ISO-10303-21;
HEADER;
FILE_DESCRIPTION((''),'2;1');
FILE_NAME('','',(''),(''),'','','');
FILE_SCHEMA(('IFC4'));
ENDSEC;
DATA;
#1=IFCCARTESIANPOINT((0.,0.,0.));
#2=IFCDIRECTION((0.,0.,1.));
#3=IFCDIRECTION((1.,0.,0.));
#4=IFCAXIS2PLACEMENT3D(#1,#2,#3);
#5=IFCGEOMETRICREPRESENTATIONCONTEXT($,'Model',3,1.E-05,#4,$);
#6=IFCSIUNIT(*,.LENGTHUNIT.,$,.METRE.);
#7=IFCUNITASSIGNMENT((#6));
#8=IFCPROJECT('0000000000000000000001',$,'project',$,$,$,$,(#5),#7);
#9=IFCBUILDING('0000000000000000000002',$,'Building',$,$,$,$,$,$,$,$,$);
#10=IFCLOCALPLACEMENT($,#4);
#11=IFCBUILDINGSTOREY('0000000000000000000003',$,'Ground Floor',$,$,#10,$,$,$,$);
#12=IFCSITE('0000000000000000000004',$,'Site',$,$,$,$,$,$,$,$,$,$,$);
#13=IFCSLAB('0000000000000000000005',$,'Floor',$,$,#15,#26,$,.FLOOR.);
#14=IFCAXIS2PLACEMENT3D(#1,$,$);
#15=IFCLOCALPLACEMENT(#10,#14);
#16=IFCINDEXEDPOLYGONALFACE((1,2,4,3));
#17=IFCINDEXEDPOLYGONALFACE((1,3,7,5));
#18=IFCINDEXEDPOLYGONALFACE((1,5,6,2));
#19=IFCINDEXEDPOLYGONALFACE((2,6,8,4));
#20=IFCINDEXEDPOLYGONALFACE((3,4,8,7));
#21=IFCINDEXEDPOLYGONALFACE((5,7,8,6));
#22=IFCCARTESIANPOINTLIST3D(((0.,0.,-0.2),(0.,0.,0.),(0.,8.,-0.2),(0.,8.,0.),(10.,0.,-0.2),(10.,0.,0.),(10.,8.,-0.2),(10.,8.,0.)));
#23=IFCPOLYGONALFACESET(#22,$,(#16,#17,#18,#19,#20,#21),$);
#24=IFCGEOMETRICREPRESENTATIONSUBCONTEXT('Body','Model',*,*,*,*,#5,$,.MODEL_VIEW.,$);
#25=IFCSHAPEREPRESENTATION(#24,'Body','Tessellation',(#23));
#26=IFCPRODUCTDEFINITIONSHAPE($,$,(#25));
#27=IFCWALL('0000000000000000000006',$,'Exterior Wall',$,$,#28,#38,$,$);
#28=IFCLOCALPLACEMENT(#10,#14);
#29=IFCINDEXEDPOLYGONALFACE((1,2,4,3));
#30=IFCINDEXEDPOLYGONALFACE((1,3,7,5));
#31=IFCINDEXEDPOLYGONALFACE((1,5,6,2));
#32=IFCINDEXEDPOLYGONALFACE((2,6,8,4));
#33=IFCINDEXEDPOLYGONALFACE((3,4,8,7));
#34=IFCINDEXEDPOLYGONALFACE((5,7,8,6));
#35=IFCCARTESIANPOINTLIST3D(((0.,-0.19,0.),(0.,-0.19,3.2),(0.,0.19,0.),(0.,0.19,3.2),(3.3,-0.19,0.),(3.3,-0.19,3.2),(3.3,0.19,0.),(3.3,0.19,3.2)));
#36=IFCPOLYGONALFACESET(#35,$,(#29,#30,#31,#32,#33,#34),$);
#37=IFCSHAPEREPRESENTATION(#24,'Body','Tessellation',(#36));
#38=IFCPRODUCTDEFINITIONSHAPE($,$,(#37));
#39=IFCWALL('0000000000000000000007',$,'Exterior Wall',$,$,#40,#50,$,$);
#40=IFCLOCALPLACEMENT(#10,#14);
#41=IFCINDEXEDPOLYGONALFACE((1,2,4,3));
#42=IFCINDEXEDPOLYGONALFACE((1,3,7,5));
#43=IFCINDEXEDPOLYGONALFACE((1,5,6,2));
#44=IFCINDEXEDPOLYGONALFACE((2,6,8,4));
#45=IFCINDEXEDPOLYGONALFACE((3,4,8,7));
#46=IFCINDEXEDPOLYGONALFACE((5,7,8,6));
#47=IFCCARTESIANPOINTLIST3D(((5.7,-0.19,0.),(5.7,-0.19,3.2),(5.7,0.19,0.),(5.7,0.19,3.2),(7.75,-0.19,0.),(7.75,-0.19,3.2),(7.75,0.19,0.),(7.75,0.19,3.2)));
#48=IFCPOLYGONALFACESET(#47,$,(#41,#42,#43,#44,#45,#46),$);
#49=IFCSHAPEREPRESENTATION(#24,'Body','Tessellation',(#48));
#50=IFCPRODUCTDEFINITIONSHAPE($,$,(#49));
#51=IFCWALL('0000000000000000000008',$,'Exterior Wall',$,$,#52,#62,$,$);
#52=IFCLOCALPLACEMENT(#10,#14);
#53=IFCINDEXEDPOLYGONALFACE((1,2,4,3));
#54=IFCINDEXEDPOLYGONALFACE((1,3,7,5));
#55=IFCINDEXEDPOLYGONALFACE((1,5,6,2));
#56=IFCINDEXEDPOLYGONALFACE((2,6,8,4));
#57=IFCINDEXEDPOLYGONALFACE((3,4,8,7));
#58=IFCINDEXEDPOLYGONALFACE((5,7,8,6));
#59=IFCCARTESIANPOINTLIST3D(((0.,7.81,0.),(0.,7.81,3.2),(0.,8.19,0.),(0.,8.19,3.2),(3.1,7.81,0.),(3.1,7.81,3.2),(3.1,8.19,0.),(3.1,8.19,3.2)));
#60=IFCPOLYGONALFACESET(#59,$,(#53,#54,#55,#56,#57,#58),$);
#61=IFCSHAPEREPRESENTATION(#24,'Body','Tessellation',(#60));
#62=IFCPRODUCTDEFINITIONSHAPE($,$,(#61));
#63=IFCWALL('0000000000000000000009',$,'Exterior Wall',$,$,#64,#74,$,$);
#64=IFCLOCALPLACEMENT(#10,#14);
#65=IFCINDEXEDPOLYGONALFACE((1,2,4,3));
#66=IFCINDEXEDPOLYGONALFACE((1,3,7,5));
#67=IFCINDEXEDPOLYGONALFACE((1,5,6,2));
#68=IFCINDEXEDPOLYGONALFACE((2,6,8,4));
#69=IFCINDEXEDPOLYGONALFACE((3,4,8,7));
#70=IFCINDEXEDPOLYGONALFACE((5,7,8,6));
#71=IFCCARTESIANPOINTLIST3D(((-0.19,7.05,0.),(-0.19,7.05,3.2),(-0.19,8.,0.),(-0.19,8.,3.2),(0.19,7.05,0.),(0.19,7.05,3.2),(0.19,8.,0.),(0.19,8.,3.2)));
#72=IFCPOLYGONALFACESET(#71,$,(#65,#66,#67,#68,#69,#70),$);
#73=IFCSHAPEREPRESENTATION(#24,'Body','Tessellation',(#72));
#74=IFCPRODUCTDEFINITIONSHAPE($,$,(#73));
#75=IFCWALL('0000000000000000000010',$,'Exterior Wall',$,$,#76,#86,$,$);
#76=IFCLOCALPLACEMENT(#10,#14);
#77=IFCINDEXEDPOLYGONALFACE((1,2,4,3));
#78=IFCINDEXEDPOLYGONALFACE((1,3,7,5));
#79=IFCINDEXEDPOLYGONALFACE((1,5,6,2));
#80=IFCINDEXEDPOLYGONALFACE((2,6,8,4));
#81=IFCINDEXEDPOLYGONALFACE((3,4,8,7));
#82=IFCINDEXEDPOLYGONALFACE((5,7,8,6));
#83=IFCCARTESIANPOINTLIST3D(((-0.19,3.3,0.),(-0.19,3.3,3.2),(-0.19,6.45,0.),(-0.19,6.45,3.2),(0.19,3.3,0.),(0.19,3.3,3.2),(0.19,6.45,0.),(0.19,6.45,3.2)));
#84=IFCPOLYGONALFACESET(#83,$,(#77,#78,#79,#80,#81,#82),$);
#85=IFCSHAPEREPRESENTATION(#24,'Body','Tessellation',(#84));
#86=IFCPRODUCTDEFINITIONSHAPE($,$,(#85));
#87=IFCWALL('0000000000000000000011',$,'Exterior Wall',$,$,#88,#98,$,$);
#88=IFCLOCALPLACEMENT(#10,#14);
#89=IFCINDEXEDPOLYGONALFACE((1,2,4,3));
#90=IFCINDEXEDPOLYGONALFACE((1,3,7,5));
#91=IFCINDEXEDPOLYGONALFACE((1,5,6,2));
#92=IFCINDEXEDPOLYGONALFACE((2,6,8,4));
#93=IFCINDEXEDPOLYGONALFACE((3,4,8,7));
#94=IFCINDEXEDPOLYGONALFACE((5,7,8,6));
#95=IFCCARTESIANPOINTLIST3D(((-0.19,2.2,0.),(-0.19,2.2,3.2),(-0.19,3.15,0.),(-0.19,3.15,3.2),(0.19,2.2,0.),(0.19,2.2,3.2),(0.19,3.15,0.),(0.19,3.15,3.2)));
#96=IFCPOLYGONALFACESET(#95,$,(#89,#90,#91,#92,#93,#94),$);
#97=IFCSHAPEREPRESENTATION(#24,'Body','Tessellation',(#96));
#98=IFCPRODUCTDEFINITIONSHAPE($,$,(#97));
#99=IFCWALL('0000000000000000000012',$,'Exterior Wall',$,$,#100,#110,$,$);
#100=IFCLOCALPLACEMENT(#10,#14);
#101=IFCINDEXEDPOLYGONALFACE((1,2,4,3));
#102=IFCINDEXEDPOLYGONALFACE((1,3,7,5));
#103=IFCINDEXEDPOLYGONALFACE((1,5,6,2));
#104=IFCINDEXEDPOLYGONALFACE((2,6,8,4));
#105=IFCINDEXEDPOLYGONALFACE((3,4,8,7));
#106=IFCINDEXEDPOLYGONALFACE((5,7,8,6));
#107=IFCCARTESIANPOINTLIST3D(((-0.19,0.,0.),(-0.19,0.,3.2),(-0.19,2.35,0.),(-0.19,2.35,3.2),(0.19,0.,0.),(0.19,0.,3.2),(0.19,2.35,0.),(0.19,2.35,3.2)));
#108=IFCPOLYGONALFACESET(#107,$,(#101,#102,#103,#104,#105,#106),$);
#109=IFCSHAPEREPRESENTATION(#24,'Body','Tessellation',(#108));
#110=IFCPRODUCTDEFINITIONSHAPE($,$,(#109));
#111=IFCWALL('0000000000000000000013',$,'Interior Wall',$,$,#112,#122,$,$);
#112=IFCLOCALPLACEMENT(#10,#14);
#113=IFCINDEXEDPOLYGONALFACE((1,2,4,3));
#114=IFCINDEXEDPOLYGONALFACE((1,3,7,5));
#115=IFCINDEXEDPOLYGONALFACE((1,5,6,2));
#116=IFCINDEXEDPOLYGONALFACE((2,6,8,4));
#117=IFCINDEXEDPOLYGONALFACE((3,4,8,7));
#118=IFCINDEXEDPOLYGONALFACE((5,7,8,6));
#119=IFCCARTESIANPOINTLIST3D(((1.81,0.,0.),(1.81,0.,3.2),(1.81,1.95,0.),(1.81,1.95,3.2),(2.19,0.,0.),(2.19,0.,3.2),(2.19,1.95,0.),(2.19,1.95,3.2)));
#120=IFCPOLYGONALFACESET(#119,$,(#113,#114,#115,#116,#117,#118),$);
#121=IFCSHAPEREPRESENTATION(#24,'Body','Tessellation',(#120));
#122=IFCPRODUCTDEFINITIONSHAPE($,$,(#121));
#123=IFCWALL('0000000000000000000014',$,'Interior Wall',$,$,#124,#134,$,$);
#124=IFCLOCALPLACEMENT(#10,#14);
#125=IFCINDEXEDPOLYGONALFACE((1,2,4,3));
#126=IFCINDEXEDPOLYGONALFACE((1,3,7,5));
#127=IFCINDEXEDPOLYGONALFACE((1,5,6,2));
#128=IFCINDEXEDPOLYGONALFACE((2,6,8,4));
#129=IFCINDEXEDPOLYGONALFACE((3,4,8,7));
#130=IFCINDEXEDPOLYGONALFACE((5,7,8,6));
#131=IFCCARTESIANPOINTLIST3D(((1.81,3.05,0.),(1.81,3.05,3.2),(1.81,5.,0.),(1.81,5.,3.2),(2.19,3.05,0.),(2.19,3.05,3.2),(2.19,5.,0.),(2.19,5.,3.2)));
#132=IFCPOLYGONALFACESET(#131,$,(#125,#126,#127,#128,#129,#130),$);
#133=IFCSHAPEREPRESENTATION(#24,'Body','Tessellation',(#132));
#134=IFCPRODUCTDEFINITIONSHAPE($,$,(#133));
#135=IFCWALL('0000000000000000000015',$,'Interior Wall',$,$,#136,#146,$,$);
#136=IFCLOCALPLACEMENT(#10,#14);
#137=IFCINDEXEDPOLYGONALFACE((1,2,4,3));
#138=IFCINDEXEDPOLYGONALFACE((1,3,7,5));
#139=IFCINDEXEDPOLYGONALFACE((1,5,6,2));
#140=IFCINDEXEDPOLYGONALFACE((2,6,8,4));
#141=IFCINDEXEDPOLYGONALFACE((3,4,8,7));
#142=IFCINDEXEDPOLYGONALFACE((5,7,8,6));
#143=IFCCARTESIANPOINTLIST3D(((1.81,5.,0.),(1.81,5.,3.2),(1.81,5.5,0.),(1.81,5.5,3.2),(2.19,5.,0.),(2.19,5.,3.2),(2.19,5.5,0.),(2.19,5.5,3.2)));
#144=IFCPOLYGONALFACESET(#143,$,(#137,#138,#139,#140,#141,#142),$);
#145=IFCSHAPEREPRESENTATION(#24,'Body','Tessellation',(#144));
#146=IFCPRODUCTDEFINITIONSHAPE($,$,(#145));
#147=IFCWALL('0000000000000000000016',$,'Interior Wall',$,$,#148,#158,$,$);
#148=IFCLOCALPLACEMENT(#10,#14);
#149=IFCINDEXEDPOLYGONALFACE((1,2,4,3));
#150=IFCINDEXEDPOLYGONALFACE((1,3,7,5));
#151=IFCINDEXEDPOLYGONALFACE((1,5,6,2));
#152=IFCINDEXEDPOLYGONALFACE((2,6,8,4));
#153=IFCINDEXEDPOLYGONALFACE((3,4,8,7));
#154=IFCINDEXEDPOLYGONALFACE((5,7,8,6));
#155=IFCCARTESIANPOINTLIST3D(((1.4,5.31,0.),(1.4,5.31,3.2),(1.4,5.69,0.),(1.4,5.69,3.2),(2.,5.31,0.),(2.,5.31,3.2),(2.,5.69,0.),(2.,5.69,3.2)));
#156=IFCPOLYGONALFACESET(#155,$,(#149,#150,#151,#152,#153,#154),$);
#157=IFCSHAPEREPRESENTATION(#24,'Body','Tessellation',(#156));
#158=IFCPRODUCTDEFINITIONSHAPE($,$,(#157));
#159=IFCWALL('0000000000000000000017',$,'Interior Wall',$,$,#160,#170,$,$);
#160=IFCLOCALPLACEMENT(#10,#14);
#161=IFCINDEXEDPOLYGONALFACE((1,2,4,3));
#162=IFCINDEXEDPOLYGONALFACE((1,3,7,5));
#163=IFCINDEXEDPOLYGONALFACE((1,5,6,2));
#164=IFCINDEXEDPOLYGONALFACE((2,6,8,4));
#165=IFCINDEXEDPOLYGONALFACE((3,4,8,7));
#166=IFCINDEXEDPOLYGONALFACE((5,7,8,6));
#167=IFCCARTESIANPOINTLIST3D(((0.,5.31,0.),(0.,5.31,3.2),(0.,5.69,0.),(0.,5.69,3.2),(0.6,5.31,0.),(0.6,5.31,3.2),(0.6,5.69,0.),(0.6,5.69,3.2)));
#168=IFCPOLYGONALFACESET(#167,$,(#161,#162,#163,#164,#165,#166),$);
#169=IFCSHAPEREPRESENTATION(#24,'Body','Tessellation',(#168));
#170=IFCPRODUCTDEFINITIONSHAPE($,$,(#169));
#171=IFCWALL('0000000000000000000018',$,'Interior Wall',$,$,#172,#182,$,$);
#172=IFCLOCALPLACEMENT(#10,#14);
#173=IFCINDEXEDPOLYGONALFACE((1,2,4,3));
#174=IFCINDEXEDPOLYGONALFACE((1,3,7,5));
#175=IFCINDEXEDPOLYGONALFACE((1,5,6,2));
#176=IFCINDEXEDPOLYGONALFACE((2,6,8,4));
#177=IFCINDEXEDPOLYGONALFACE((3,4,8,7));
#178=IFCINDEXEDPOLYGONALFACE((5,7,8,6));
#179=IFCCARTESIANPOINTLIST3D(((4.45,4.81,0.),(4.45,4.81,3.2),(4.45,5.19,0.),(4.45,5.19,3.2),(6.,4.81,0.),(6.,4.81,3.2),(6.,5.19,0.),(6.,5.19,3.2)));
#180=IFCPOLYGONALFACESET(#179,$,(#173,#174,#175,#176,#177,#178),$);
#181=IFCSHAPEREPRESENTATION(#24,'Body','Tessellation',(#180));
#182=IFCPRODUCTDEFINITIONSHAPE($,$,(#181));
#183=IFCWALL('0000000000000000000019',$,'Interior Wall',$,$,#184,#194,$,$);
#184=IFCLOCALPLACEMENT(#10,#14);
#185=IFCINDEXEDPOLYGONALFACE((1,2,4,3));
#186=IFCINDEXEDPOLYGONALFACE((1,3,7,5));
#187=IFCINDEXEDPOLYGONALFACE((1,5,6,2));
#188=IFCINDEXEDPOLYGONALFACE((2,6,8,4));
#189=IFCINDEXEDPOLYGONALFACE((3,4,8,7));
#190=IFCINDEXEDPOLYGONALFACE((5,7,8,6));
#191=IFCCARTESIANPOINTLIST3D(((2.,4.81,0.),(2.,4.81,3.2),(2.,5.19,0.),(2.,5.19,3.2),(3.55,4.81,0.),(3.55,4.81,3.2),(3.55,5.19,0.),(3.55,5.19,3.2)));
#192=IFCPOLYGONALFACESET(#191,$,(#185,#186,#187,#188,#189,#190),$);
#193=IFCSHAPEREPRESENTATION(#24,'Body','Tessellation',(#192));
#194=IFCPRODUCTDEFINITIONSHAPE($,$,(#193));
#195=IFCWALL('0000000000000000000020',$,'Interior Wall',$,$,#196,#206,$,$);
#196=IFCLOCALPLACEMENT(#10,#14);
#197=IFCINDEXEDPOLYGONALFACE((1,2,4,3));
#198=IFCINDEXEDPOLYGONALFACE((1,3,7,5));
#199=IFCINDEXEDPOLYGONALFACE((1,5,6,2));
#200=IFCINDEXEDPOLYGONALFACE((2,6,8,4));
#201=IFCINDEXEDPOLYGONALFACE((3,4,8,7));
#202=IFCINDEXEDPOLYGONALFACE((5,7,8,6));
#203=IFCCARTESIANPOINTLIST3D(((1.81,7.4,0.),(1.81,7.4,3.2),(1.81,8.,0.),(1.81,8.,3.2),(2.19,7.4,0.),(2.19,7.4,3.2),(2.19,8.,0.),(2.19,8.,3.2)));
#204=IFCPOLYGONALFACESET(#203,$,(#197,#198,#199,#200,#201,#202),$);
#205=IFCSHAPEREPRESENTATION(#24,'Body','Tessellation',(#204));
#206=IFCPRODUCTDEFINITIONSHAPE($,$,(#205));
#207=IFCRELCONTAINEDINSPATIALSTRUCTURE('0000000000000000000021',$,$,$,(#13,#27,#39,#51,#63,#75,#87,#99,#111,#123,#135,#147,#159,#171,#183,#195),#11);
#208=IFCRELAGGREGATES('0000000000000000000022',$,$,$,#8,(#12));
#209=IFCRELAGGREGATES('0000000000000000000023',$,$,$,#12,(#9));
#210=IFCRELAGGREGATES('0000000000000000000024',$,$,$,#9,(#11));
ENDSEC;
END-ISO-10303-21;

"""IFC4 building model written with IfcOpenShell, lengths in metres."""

from ifc_helpers import new_model, si_unit, frame, origin_with_axes, place, context, subcontext, project, spatial, indexed_curve, outline, extrude, element, save


model = new_model("IFC4")

# Units and contexts
model_context = context("Model", 3, precision=1e-05, world=origin_with_axes())
body_context = subcontext(model_context, "Body", "Model", "MODEL_VIEW")
ifc_project = project(units=[si_unit("LENGTHUNIT", "METRE")], contexts=[model_context])

# Site, building, storey
site = spatial("IfcSite", under=ifc_project, Name="Site")
building = spatial("IfcBuilding", under=site, Name="Building")
storey_placement = place(None, origin_with_axes())
storey = spatial("IfcBuildingStorey", under=building, at=storey_placement, Name="Ground Floor")

# Slab
slab_placement = place(storey_placement, frame((0.0, 0.0, -0.2), z_axis=(0.0, 0.0, 1.0), x_axis=(1.0, 0.0, 0.0)))
element("IfcSlab", 1, at=slab_placement, inside=storey, Name="Floor", PredefinedType="FLOOR", context=body_context, shape_type="SweptSolid", body=[
    extrude(outline(indexed_curve([(0.0, 0.0), (10.0, 0.0), (10.0, 8.0), (0.0, 8.0)])), None, (0.0, 0.0, 1.0), 0.2),
])

# Walls
wall_1_placement = place(storey_placement, origin_with_axes())
element("IfcWall", 2, at=wall_1_placement, inside=storey, Name="Exterior Wall", context=body_context, shape_type="SweptSolid", body=[
    extrude(outline(indexed_curve([(0.0, 0.0), (0.0, 0.38), (3.3, 0.38), (3.3, 0.0), (0.0, 0.0)], self_intersect=False)), frame((0.0, -0.19, 0.0), z_axis=(0.0, 0.0, 1.0), x_axis=(1.0, 0.0, 0.0)), (0.0, 0.0, 1.0), 3.2),
])
wall_2_placement = place(storey_placement, frame((5.7, 0.0, 0.0), z_axis=(0.0, 0.0, 1.0), x_axis=(1.0, 0.0, 0.0)))
element("IfcWall", 3, at=wall_2_placement, inside=storey, Name="Exterior Wall", context=body_context, shape_type="SweptSolid", body=[
    extrude(outline(indexed_curve([(0.0, 0.0), (0.0, 0.38), (2.05, 0.38), (2.05, 0.0), (0.0, 0.0)], self_intersect=False)), frame((0.0, -0.19, 0.0), z_axis=(0.0, 0.0, 1.0), x_axis=(1.0, 0.0, 0.0)), (0.0, 0.0, 1.0), 3.2),
])
wall_3_placement = place(storey_placement, frame((3.1, 8.0, 0.0), z_axis=(0.0, 0.0, 1.0), x_axis=(-1.0, 0.0, 0.0)))
element("IfcWall", 4, at=wall_3_placement, inside=storey, Name="Exterior Wall", context=body_context, shape_type="SweptSolid", body=[
    extrude(outline(indexed_curve([(0.0, 0.0), (0.0, 0.38), (3.1, 0.38), (3.1, 0.0), (0.0, 0.0)], self_intersect=False)), frame((0.0, -0.19, 0.0), z_axis=(0.0, 0.0, 1.0), x_axis=(1.0, 0.0, 0.0)), (0.0, 0.0, 1.0), 3.2),
])
wall_4_placement = place(storey_placement, frame((0.0, 8.0, 0.0), z_axis=(0.0, 0.0, 1.0), x_axis=(0.0, -1.0, 0.0)))
element("IfcWall", 5, at=wall_4_placement, inside=storey, Name="Exterior Wall", context=body_context, shape_type="SweptSolid", body=[
    extrude(outline(indexed_curve([(0.0, 0.0), (0.0, 0.38), (0.95, 0.38), (0.95, 0.0), (0.0, 0.0)], self_intersect=False)), frame((0.0, -0.19, 0.0), z_axis=(0.0, 0.0, 1.0), x_axis=(1.0, 0.0, 0.0)), (0.0, 0.0, 1.0), 3.2),
])
wall_5_placement = place(storey_placement, frame((0.0, 6.45, 0.0), z_axis=(0.0, 0.0, 1.0), x_axis=(0.0, -1.0, 0.0)))
element("IfcWall", 6, at=wall_5_placement, inside=storey, Name="Exterior Wall", context=body_context, shape_type="SweptSolid", body=[
    extrude(outline(indexed_curve([(0.0, 0.0), (0.0, 0.38), (3.15, 0.38), (3.15, 0.0), (0.0, 0.0)], self_intersect=False)), frame((0.0, -0.19, 0.0), z_axis=(0.0, 0.0, 1.0), x_axis=(1.0, 0.0, 0.0)), (0.0, 0.0, 1.0), 3.2),
])
wall_6_placement = place(storey_placement, frame((0.0, 2.2, 0.0), z_axis=(0.0, 0.0, 1.0), x_axis=(0.0, 1.0, 0.0)))
element("IfcWall", 7, at=wall_6_placement, inside=storey, Name="Exterior Wall", context=body_context, shape_type="SweptSolid", body=[
    extrude(outline(indexed_curve([(0.0, 0.0), (0.0, 0.38), (0.95, 0.38), (0.95, 0.0), (0.0, 0.0)], self_intersect=False)), frame((0.0, -0.19, 0.0), z_axis=(0.0, 0.0, 1.0), x_axis=(1.0, 0.0, 0.0)), (0.0, 0.0, 1.0), 3.2),
])
wall_7_placement = place(storey_placement, frame((0.0, 2.35, 0.0), z_axis=(0.0, 0.0, 1.0), x_axis=(0.0, -1.0, 0.0)))
element("IfcWall", 8, at=wall_7_placement, inside=storey, Name="Exterior Wall", context=body_context, shape_type="SweptSolid", body=[
    extrude(outline(indexed_curve([(0.0, 0.0), (0.0, 0.38), (2.35, 0.38), (2.35, 0.0), (0.0, 0.0)], self_intersect=False)), frame((0.0, -0.19, 0.0), z_axis=(0.0, 0.0, 1.0), x_axis=(1.0, 0.0, 0.0)), (0.0, 0.0, 1.0), 3.2),
])
wall_8_placement = place(storey_placement, frame((2.0, 0.0, 0.0), z_axis=(0.0, 0.0, 1.0), x_axis=(0.0, 1.0, 0.0)))
element("IfcWall", 9, at=wall_8_placement, inside=storey, Name="Interior Wall", context=body_context, shape_type="SweptSolid", body=[
    extrude(outline(indexed_curve([(0.0, 0.0), (0.0, 0.38), (1.95, 0.38), (1.95, 0.0), (0.0, 0.0)], self_intersect=False)), frame((0.0, -0.19, 0.0), z_axis=(0.0, 0.0, 1.0), x_axis=(1.0, 0.0, 0.0)), (0.0, 0.0, 1.0), 3.2),
])
wall_9_placement = place(storey_placement, frame((2.0, 3.05, 0.0), z_axis=(0.0, 0.0, 1.0), x_axis=(0.0, 1.0, 0.0)))
element("IfcWall", 10, at=wall_9_placement, inside=storey, Name="Interior Wall", context=body_context, shape_type="SweptSolid", body=[
    extrude(outline(indexed_curve([(0.0, 0.0), (0.0, 0.38), (1.95, 0.38), (1.95, 0.0), (0.0, 0.0)], self_intersect=False)), frame((0.0, -0.19, 0.0), z_axis=(0.0, 0.0, 1.0), x_axis=(1.0, 0.0, 0.0)), (0.0, 0.0, 1.0), 3.2),
])
wall_10_placement = place(storey_placement, frame((2.0, 5.0, 0.0), z_axis=(0.0, 0.0, 1.0), x_axis=(0.0, 1.0, 0.0)))
element("IfcWall", 11, at=wall_10_placement, inside=storey, Name="Interior Wall", context=body_context, shape_type="SweptSolid", body=[
    extrude(outline(indexed_curve([(0.0, 0.0), (0.0, 0.38), (0.5, 0.38), (0.5, 0.0), (0.0, 0.0)], self_intersect=False)), frame((0.0, -0.19, 0.0), z_axis=(0.0, 0.0, 1.0), x_axis=(1.0, 0.0, 0.0)), (0.0, 0.0, 1.0), 3.2),
])
for number, where, z_axis, x_axis, name in (
    (12, (2.0, 5.5, 0.0), (0.0, 0.0, 1.0), (-1.0, 0.0, 0.0), "Interior Wall"),
    (13, (0.6, 5.5, 0.0), (0.0, 0.0, 1.0), (-1.0, 0.0, 0.0), "Interior Wall"),
):
    element("IfcWall", number, at=place(storey_placement, frame(where, z_axis=z_axis, x_axis=x_axis)), inside=storey, Name=name, context=body_context, shape_type="SweptSolid", body=[
        extrude(outline(indexed_curve([(0.0, 0.0), (0.0, 0.38), (0.6, 0.38), (0.6, 0.0), (0.0, 0.0)], self_intersect=False)), frame((0.0, -0.19, 0.0), z_axis=(0.0, 0.0, 1.0), x_axis=(1.0, 0.0, 0.0)), (0.0, 0.0, 1.0), 3.2),
    ])
for number, where, z_axis, x_axis, name in (
    (14, (6.0, 5.0, 0.0), (0.0, 0.0, 1.0), (-1.0, 0.0, 0.0), "Interior Wall"),
    (15, (3.55, 5.0, 0.0), (0.0, 0.0, 1.0), (-1.0, 0.0, 0.0), "Interior Wall"),
):
    element("IfcWall", number, at=place(storey_placement, frame(where, z_axis=z_axis, x_axis=x_axis)), inside=storey, Name=name, context=body_context, shape_type="SweptSolid", body=[
        extrude(outline(indexed_curve([(0.0, 0.0), (0.0, 0.38), (1.55, 0.38), (1.55, 0.0), (0.0, 0.0)], self_intersect=False)), frame((0.0, -0.19, 0.0), z_axis=(0.0, 0.0, 1.0), x_axis=(1.0, 0.0, 0.0)), (0.0, 0.0, 1.0), 3.2),
    ])
wall_11_placement = place(storey_placement, frame((2.0, 8.0, 0.0), z_axis=(0.0, 0.0, 1.0), x_axis=(0.0, -1.0, 0.0)))
element("IfcWall", 16, at=wall_11_placement, inside=storey, Name="Interior Wall", context=body_context, shape_type="SweptSolid", body=[
    extrude(outline(indexed_curve([(0.0, 0.0), (0.0, 0.38), (0.6, 0.38), (0.6, 0.0), (0.0, 0.0)], self_intersect=False)), frame((0.0, -0.19, 0.0), z_axis=(0.0, 0.0, 1.0), x_axis=(1.0, 0.0, 0.0)), (0.0, 0.0, 1.0), 3.2),
])

save(model, "model.ifc")
